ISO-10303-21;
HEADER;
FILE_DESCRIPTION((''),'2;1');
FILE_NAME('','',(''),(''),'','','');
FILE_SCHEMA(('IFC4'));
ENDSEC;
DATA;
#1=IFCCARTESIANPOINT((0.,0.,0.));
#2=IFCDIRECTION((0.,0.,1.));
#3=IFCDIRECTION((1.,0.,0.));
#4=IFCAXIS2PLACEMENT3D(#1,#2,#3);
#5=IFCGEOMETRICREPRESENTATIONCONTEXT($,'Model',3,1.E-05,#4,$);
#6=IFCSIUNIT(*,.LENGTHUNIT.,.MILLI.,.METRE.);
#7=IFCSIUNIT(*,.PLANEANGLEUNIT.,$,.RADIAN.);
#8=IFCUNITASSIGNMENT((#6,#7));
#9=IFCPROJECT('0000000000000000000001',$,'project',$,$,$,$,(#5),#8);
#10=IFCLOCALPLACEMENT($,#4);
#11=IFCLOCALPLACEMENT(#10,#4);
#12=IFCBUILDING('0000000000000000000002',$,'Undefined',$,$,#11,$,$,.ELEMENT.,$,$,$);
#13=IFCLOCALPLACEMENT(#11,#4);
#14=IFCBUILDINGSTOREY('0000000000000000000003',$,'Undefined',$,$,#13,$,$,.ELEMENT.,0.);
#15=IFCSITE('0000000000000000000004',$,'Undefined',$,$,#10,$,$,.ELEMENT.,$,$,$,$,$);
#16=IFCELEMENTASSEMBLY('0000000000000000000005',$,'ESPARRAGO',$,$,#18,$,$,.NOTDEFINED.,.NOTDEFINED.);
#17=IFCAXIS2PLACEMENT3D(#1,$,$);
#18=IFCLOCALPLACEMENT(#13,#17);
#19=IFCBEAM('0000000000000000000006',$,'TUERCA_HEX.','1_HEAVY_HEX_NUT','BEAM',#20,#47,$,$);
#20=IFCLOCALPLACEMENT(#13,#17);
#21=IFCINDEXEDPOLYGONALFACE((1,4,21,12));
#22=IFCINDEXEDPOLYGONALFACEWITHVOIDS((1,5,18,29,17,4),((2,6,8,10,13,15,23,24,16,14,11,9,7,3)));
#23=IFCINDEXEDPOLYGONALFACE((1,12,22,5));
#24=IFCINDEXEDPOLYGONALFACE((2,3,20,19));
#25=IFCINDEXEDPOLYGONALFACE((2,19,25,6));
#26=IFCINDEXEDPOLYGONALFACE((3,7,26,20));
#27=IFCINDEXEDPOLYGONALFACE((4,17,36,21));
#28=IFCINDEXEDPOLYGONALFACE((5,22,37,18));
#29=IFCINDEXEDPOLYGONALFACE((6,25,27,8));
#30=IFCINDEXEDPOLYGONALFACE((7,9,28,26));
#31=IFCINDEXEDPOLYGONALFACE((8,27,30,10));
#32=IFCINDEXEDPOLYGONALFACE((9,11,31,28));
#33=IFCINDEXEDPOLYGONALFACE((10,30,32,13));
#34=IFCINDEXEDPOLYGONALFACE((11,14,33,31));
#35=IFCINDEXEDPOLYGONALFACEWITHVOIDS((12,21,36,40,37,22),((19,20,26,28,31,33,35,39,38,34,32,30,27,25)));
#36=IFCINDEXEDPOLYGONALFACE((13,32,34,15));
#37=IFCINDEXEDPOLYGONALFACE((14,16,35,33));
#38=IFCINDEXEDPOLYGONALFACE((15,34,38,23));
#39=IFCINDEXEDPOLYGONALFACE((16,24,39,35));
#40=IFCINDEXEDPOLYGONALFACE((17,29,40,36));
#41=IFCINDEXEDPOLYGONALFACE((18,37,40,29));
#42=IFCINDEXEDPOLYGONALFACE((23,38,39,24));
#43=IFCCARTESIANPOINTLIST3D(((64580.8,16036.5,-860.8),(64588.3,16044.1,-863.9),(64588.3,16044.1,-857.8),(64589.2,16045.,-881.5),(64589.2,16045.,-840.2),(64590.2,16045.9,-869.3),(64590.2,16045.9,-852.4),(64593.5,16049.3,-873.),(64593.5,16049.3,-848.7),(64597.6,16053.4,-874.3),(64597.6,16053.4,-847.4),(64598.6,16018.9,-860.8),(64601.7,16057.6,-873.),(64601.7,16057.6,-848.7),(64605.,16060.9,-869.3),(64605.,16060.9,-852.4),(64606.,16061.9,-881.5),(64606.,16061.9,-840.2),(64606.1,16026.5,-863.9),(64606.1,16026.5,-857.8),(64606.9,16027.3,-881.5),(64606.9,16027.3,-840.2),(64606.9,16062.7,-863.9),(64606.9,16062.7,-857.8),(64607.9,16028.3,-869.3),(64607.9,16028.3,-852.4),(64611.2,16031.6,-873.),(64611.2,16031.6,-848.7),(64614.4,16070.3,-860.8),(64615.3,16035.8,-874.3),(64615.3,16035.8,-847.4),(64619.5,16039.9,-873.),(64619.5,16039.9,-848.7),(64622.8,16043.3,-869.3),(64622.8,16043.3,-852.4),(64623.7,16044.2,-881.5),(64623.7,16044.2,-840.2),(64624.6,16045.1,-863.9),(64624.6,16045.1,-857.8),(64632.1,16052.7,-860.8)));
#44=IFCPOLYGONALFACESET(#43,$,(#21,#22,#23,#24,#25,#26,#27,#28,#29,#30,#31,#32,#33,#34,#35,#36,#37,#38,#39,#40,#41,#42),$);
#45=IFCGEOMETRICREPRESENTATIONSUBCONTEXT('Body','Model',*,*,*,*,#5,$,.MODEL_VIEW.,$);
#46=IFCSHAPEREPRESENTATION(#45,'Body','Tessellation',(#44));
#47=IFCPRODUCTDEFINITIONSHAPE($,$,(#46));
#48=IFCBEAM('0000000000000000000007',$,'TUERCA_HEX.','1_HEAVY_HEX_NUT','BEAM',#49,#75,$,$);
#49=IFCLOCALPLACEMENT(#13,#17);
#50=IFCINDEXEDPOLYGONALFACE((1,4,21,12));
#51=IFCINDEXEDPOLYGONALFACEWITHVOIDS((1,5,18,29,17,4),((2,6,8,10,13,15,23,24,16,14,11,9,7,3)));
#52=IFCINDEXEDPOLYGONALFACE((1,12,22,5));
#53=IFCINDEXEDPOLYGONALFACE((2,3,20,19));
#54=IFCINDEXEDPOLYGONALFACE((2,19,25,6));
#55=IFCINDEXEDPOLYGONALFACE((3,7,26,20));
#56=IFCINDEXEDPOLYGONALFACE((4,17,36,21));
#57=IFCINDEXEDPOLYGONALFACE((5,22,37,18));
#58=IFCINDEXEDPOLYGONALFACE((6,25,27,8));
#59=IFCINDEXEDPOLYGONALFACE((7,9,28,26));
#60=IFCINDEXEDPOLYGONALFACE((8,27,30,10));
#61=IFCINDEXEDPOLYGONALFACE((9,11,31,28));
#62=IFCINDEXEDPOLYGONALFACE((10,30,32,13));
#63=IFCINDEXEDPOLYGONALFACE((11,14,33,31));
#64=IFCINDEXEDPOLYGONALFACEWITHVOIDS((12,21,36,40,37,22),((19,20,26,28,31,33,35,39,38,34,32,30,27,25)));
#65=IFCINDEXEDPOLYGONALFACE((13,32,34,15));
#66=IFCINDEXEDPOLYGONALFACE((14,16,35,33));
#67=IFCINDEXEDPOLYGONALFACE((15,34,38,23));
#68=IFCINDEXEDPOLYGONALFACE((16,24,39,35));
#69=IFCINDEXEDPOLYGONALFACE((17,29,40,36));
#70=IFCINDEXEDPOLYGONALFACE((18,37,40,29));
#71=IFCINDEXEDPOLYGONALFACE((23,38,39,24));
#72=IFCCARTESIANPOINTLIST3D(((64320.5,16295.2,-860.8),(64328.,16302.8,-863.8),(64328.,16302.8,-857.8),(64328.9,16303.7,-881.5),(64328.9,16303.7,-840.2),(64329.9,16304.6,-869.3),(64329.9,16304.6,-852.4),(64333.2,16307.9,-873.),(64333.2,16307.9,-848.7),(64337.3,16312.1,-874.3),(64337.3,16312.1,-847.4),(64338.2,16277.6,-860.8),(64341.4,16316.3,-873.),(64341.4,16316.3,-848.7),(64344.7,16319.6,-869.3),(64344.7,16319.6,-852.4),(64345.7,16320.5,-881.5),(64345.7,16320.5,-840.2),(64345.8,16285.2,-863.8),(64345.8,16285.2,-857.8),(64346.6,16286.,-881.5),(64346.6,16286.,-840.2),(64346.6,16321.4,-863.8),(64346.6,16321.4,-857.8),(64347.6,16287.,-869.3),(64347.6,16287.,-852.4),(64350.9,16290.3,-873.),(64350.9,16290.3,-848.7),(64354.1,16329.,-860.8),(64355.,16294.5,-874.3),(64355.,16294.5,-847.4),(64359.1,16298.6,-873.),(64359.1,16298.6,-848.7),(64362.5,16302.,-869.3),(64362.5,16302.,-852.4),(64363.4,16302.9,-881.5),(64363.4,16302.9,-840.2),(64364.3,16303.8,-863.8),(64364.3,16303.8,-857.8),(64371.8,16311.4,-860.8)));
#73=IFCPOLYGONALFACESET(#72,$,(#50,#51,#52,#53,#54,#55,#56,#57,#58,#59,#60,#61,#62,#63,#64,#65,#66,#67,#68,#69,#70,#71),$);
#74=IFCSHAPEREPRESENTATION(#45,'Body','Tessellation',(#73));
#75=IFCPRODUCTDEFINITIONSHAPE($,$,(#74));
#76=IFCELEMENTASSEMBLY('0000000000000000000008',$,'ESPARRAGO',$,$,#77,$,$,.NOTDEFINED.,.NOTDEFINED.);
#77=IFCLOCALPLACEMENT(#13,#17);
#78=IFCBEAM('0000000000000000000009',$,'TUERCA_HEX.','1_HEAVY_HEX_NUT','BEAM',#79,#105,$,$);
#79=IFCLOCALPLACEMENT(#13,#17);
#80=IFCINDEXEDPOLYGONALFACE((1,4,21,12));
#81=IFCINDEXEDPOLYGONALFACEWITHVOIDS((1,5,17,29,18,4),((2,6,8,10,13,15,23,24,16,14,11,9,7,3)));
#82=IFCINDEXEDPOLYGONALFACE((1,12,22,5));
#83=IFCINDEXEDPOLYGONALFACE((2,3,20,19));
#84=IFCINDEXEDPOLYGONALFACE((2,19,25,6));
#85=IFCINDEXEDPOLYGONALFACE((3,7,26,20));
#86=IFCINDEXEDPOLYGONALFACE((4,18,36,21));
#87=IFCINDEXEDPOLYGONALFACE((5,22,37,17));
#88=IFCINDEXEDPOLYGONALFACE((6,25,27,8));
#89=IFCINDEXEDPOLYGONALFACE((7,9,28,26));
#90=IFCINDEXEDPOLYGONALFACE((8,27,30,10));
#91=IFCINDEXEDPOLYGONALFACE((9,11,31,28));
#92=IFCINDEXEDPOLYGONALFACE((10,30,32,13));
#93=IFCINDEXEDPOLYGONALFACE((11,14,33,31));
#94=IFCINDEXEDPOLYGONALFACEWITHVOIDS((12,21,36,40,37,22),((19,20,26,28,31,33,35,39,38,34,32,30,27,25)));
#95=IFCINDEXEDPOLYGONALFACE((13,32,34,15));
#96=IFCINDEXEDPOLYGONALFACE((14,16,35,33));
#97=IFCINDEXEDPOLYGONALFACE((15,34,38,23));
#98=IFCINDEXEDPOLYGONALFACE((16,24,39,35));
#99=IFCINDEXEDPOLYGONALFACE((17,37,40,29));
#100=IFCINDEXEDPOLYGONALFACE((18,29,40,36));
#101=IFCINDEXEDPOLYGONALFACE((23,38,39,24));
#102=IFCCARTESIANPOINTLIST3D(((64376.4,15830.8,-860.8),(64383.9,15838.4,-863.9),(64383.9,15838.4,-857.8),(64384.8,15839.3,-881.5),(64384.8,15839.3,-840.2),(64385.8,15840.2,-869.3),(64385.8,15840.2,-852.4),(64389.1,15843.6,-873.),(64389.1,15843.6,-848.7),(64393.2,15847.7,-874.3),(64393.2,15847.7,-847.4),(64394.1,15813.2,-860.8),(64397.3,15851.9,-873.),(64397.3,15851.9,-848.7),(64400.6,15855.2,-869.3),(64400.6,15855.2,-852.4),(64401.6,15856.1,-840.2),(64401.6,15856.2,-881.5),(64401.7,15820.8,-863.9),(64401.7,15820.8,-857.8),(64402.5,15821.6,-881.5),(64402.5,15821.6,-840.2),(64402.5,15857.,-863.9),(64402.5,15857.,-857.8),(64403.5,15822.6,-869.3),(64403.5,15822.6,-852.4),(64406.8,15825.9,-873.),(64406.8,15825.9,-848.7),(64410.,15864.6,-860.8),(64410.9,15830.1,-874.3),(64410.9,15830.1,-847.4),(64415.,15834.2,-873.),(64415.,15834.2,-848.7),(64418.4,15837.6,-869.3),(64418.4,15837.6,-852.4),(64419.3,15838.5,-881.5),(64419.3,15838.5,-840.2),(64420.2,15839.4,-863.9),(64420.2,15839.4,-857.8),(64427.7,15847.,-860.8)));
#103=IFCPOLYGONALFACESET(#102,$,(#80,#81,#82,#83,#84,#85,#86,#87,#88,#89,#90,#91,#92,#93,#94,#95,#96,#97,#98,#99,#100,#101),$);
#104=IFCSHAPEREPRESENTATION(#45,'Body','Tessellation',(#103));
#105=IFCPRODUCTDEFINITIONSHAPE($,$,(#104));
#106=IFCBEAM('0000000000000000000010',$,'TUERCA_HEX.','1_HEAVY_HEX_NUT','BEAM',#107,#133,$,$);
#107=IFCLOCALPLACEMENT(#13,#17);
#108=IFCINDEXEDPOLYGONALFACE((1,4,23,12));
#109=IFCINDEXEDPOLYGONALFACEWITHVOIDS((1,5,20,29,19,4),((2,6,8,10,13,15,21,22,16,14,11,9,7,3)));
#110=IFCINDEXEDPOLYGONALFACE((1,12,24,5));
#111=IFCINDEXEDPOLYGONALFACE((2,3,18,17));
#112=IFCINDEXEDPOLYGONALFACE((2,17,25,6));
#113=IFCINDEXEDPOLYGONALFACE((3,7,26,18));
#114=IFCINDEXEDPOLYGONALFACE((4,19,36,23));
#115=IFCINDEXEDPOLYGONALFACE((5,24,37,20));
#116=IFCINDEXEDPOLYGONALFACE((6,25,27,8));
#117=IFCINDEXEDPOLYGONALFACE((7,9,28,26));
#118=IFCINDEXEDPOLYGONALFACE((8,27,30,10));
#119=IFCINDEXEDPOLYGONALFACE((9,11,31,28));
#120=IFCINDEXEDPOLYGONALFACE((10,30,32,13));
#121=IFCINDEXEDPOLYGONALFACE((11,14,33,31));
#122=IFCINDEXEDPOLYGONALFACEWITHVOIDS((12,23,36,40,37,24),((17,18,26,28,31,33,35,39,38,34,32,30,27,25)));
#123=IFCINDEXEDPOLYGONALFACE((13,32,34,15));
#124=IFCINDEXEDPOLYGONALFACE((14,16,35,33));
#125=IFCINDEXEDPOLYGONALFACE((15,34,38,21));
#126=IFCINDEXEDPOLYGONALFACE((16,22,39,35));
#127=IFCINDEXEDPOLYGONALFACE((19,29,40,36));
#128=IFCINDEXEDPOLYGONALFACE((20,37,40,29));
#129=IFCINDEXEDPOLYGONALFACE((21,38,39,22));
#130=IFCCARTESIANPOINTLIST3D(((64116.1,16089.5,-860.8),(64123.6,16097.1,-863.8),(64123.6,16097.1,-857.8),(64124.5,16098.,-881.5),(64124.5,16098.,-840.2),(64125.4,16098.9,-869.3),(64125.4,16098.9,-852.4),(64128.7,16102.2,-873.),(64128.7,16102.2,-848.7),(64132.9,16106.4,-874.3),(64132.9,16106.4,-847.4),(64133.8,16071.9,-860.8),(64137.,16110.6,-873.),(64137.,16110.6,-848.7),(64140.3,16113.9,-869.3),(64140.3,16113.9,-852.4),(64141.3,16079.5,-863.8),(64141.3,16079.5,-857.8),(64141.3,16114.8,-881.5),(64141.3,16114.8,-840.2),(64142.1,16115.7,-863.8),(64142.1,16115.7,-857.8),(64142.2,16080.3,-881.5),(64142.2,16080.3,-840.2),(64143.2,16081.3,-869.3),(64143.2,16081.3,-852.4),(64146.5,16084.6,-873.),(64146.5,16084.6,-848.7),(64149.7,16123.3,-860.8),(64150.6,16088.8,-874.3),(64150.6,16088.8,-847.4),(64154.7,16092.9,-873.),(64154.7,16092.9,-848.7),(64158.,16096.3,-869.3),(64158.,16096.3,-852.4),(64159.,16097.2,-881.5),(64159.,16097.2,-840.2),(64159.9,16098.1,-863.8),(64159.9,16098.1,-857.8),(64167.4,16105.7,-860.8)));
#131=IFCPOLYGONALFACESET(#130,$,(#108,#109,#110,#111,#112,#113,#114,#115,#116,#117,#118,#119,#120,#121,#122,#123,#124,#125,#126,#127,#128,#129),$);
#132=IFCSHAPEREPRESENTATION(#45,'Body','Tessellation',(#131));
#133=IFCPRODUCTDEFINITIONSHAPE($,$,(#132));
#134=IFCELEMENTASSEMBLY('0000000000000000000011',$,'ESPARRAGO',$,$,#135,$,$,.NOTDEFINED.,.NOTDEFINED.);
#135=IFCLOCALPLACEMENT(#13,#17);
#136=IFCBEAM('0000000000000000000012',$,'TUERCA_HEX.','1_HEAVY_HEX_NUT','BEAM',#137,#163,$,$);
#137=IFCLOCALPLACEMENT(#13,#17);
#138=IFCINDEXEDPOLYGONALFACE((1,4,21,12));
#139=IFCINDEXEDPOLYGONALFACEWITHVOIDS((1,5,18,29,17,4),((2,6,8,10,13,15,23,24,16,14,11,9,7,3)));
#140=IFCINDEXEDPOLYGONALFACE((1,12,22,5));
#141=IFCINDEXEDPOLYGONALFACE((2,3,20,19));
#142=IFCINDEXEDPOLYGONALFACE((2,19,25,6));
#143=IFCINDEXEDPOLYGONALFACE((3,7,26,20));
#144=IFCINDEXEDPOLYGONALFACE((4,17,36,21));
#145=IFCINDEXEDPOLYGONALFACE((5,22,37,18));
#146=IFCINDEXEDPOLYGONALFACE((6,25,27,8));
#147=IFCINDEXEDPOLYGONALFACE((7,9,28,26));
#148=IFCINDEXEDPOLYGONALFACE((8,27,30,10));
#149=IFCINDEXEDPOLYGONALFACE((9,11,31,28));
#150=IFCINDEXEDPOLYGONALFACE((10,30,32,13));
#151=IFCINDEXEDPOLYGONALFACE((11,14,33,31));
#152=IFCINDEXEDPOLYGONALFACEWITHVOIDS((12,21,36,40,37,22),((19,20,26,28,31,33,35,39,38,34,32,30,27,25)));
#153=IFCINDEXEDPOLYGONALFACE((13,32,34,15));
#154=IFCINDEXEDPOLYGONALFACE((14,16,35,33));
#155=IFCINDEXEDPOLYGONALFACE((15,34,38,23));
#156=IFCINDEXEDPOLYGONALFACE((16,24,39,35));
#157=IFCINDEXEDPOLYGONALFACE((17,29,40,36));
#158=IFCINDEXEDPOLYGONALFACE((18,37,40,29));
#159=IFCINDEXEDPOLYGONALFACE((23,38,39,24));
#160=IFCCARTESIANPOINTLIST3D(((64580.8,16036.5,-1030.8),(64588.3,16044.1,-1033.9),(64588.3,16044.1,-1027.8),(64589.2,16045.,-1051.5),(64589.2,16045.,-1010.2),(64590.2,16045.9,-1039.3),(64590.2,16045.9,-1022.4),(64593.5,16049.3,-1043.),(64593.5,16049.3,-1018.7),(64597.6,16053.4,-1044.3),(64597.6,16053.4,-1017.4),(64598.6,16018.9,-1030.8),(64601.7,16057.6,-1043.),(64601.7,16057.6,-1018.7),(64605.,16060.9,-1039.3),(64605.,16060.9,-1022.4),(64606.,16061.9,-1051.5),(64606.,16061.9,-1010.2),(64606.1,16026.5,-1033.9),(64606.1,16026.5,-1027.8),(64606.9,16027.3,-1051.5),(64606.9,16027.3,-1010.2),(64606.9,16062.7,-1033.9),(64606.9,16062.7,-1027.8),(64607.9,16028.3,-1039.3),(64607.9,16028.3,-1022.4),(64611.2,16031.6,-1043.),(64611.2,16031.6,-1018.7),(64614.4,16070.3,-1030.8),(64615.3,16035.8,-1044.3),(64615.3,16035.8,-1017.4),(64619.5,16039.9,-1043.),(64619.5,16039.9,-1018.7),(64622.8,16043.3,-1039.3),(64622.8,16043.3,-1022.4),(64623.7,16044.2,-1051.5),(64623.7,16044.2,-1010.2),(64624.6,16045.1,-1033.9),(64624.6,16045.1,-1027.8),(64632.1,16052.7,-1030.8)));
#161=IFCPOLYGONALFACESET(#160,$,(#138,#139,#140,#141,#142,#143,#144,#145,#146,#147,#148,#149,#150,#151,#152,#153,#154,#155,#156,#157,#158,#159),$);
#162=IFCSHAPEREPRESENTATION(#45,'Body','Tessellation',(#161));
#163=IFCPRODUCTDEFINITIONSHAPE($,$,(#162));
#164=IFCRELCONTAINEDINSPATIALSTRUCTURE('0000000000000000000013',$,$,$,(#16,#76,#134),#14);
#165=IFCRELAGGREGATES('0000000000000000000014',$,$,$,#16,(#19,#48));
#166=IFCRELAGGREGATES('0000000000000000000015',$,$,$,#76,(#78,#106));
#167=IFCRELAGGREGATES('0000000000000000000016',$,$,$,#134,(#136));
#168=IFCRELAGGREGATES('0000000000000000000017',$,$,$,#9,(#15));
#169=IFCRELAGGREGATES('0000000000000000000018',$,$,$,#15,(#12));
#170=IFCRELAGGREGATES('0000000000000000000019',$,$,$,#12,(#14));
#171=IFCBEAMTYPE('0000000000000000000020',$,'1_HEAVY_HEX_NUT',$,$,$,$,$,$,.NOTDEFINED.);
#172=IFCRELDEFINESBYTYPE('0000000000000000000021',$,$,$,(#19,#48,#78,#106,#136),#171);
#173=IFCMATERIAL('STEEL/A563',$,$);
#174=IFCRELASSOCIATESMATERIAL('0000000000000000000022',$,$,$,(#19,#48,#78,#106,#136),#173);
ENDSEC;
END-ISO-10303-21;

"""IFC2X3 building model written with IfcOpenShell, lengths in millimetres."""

from ifc_helpers import new_model, si_unit, frame, origin_with_axes, place, context, subcontext, project, spatial, polyline, outline, extrude, material, type_object, element, aggregate, save


model = new_model("IFC2X3")

# Units and contexts
model_context = context("Model", 3, precision=1e-05, world=origin_with_axes())
body_context = subcontext(model_context, "Body", "Model", "MODEL_VIEW")
ifc_project = project(units=[si_unit("LENGTHUNIT", "METRE", prefix="MILLI"), si_unit("PLANEANGLEUNIT", "RADIAN")], contexts=[model_context])

# Site, building, storey
site_placement = place(None, origin_with_axes())
site = spatial("IfcSite", under=ifc_project, at=site_placement, Name="Undefined", CompositionType="ELEMENT")
building_placement = place(site_placement, origin_with_axes())
building = spatial("IfcBuilding", under=site, at=building_placement, Name="Undefined", CompositionType="ELEMENT")
storey_placement = place(building_placement, origin_with_axes())
storey = spatial("IfcBuildingStorey", under=building, at=storey_placement, Name="Undefined", CompositionType="ELEMENT", Elevation=0.0)

# Element assemblies, beams
assembly_1_placement = place(storey_placement, origin_with_axes())
assembly_1 = element("IfcElementAssembly", 1, at=assembly_1_placement, inside=storey, Name="ESPARRAGO", AssemblyPlace="NOTDEFINED", PredefinedType="NOTDEFINED")
ifc_material_1 = material(Name="STEEL/A563")
beam_type_1 = type_object("IfcBeamType", Name="1_HEAVY_HEX_NUT", PredefinedType="NOTDEFINED")
beam_1_placement = place(assembly_1_placement, frame((64597.6, 16053.4, -860.8), z_axis=(0.00001, -0.00001, 1.0), x_axis=(0.709311, -0.704895, -0.000014)))
beam_1 = element("IfcBeam", 2, at=beam_1_placement, type_object=beam_type_1, material=ifc_material_1, Name="TUERCA_HEX.", Description="1_HEAVY_HEX_NUT", ObjectType="BEAM", context=body_context, shape_type="SweptSolid", body=[
    extrude(outline(polyline([(11.9, -20.6), (-11.9, -20.6), (-23.8, 0.0), (-11.9, 20.6), (11.9, 20.6), (23.8, 0.0), (11.9, -20.6)]), holes=[polyline([(-5.9, 12.2), (-10.5, 8.4), (-13.2, 3.0), (-13.2, -3.0), (-10.5, -8.4), (-5.9, -12.2), (0.0, -13.5), (5.9, -12.2), (10.5, -8.4), (13.2, -3.0), (13.2, 3.0), (10.5, 8.4), (5.9, 12.2), (0.0, 13.5), (-5.9, 12.2)])]), frame((25.0, 0.0, 0.0), z_axis=(-1.0, 0.0, 0.0), x_axis=(0.0, -1.0, 0.0)), (0.0, 0.0, 1.0), 25.0),
])
beam_2_placement = place(assembly_1_placement, frame((64337.3, 16312.1, -860.8), z_axis=(0.00001, -0.00001, 1.0), x_axis=(0.709311, -0.704895, -0.000014)))
beam_2 = element("IfcBeam", 3, at=beam_2_placement, type_object=beam_type_1, material=ifc_material_1, Name="TUERCA_HEX.", Description="1_HEAVY_HEX_NUT", ObjectType="BEAM", context=body_context, shape_type="SweptSolid", body=[
    extrude(outline(polyline([(11.9, -20.6), (-11.9, -20.6), (-23.8, 0.0), (-11.9, 20.6), (11.9, 20.6), (23.8, 0.0), (11.9, -20.6)]), holes=[polyline([(-5.9, 12.2), (-10.5, 8.4), (-13.2, 3.0), (-13.2, -3.0), (-10.5, -8.4), (-5.9, -12.2), (0.0, -13.5), (5.9, -12.2), (10.5, -8.4), (13.2, -3.0), (13.2, 3.0), (10.5, 8.4), (5.9, 12.2), (0.0, 13.5), (-5.9, 12.2)])]), frame((25.0, 0.0, 0.0), z_axis=(-1.0, 0.0, 0.0), x_axis=(0.0, -1.0, 0.0)), (0.0, 0.0, 1.0), 25.0),
])
assembly_2_placement = place(storey_placement, origin_with_axes())
assembly_2 = element("IfcElementAssembly", 4, at=assembly_2_placement, inside=storey, Name="ESPARRAGO", AssemblyPlace="NOTDEFINED", PredefinedType="NOTDEFINED")
beam_3_placement = place(assembly_2_placement, frame((64393.2, 15847.7, -860.8), z_axis=(0.00001, -0.00001, 1.0), x_axis=(0.709311, -0.704895, -0.000014)))
beam_3 = element("IfcBeam", 5, at=beam_3_placement, type_object=beam_type_1, material=ifc_material_1, Name="TUERCA_HEX.", Description="1_HEAVY_HEX_NUT", ObjectType="BEAM", context=body_context, shape_type="SweptSolid", body=[
    extrude(outline(polyline([(11.9, -20.6), (-11.9, -20.6), (-23.8, 0.0), (-11.9, 20.6), (11.9, 20.6), (23.8, 0.0), (11.9, -20.6)]), holes=[polyline([(-5.9, 12.2), (-10.5, 8.4), (-13.2, 3.0), (-13.2, -3.0), (-10.5, -8.4), (-5.9, -12.2), (0.0, -13.5), (5.9, -12.2), (10.5, -8.4), (13.2, -3.0), (13.2, 3.0), (10.5, 8.4), (5.9, 12.2), (0.0, 13.5), (-5.9, 12.2)])]), frame((25.0, 0.0, 0.0), z_axis=(-1.0, 0.0, 0.0), x_axis=(0.0, -1.0, 0.0)), (0.0, 0.0, 1.0), 25.0),
])
beam_4_placement = place(assembly_2_placement, frame((64132.9, 16106.4, -860.8), z_axis=(0.00001, -0.00001, 1.0), x_axis=(0.709311, -0.704895, -0.000014)))
beam_4 = element("IfcBeam", 6, at=beam_4_placement, type_object=beam_type_1, material=ifc_material_1, Name="TUERCA_HEX.", Description="1_HEAVY_HEX_NUT", ObjectType="BEAM", context=body_context, shape_type="SweptSolid", body=[
    extrude(outline(polyline([(11.9, -20.6), (-11.9, -20.6), (-23.8, 0.0), (-11.9, 20.6), (11.9, 20.6), (23.8, 0.0), (11.9, -20.6)]), holes=[polyline([(-5.9, 12.2), (-10.5, 8.4), (-13.2, 3.0), (-13.2, -3.0), (-10.5, -8.4), (-5.9, -12.2), (0.0, -13.5), (5.9, -12.2), (10.5, -8.4), (13.2, -3.0), (13.2, 3.0), (10.5, 8.4), (5.9, 12.2), (0.0, 13.5), (-5.9, 12.2)])]), frame((25.0, 0.0, 0.0), z_axis=(-1.0, 0.0, 0.0), x_axis=(0.0, -1.0, 0.0)), (0.0, 0.0, 1.0), 25.0),
])
assembly_3_placement = place(storey_placement, origin_with_axes())
assembly_3 = element("IfcElementAssembly", 7, at=assembly_3_placement, inside=storey, Name="ESPARRAGO", AssemblyPlace="NOTDEFINED", PredefinedType="NOTDEFINED")
beam_5_placement = place(assembly_3_placement, frame((64597.6, 16053.4, -1030.8), z_axis=(0.00001, -0.00001, 1.0), x_axis=(0.709311, -0.704895, -0.000014)))
beam_5 = element("IfcBeam", 8, at=beam_5_placement, type_object=beam_type_1, material=ifc_material_1, Name="TUERCA_HEX.", Description="1_HEAVY_HEX_NUT", ObjectType="BEAM", context=body_context, shape_type="SweptSolid", body=[
    extrude(outline(polyline([(11.9, -20.6), (-11.9, -20.6), (-23.8, 0.0), (-11.9, 20.6), (11.9, 20.6), (23.8, 0.0), (11.9, -20.6)]), holes=[polyline([(-5.9, 12.2), (-10.5, 8.4), (-13.2, 3.0), (-13.2, -3.0), (-10.5, -8.4), (-5.9, -12.2), (0.0, -13.5), (5.9, -12.2), (10.5, -8.4), (13.2, -3.0), (13.2, 3.0), (10.5, 8.4), (5.9, 12.2), (0.0, 13.5), (-5.9, 12.2)])]), frame((25.0, 0.0, 0.0), z_axis=(-1.0, 0.0, 0.0), x_axis=(0.0, -1.0, 0.0)), (0.0, 0.0, 1.0), 25.0),
])

aggregate(assembly_1, [beam_1, beam_2])
aggregate(assembly_2, [beam_3, beam_4])
aggregate(assembly_3, [beam_5])

save(model, "model.ifc")
